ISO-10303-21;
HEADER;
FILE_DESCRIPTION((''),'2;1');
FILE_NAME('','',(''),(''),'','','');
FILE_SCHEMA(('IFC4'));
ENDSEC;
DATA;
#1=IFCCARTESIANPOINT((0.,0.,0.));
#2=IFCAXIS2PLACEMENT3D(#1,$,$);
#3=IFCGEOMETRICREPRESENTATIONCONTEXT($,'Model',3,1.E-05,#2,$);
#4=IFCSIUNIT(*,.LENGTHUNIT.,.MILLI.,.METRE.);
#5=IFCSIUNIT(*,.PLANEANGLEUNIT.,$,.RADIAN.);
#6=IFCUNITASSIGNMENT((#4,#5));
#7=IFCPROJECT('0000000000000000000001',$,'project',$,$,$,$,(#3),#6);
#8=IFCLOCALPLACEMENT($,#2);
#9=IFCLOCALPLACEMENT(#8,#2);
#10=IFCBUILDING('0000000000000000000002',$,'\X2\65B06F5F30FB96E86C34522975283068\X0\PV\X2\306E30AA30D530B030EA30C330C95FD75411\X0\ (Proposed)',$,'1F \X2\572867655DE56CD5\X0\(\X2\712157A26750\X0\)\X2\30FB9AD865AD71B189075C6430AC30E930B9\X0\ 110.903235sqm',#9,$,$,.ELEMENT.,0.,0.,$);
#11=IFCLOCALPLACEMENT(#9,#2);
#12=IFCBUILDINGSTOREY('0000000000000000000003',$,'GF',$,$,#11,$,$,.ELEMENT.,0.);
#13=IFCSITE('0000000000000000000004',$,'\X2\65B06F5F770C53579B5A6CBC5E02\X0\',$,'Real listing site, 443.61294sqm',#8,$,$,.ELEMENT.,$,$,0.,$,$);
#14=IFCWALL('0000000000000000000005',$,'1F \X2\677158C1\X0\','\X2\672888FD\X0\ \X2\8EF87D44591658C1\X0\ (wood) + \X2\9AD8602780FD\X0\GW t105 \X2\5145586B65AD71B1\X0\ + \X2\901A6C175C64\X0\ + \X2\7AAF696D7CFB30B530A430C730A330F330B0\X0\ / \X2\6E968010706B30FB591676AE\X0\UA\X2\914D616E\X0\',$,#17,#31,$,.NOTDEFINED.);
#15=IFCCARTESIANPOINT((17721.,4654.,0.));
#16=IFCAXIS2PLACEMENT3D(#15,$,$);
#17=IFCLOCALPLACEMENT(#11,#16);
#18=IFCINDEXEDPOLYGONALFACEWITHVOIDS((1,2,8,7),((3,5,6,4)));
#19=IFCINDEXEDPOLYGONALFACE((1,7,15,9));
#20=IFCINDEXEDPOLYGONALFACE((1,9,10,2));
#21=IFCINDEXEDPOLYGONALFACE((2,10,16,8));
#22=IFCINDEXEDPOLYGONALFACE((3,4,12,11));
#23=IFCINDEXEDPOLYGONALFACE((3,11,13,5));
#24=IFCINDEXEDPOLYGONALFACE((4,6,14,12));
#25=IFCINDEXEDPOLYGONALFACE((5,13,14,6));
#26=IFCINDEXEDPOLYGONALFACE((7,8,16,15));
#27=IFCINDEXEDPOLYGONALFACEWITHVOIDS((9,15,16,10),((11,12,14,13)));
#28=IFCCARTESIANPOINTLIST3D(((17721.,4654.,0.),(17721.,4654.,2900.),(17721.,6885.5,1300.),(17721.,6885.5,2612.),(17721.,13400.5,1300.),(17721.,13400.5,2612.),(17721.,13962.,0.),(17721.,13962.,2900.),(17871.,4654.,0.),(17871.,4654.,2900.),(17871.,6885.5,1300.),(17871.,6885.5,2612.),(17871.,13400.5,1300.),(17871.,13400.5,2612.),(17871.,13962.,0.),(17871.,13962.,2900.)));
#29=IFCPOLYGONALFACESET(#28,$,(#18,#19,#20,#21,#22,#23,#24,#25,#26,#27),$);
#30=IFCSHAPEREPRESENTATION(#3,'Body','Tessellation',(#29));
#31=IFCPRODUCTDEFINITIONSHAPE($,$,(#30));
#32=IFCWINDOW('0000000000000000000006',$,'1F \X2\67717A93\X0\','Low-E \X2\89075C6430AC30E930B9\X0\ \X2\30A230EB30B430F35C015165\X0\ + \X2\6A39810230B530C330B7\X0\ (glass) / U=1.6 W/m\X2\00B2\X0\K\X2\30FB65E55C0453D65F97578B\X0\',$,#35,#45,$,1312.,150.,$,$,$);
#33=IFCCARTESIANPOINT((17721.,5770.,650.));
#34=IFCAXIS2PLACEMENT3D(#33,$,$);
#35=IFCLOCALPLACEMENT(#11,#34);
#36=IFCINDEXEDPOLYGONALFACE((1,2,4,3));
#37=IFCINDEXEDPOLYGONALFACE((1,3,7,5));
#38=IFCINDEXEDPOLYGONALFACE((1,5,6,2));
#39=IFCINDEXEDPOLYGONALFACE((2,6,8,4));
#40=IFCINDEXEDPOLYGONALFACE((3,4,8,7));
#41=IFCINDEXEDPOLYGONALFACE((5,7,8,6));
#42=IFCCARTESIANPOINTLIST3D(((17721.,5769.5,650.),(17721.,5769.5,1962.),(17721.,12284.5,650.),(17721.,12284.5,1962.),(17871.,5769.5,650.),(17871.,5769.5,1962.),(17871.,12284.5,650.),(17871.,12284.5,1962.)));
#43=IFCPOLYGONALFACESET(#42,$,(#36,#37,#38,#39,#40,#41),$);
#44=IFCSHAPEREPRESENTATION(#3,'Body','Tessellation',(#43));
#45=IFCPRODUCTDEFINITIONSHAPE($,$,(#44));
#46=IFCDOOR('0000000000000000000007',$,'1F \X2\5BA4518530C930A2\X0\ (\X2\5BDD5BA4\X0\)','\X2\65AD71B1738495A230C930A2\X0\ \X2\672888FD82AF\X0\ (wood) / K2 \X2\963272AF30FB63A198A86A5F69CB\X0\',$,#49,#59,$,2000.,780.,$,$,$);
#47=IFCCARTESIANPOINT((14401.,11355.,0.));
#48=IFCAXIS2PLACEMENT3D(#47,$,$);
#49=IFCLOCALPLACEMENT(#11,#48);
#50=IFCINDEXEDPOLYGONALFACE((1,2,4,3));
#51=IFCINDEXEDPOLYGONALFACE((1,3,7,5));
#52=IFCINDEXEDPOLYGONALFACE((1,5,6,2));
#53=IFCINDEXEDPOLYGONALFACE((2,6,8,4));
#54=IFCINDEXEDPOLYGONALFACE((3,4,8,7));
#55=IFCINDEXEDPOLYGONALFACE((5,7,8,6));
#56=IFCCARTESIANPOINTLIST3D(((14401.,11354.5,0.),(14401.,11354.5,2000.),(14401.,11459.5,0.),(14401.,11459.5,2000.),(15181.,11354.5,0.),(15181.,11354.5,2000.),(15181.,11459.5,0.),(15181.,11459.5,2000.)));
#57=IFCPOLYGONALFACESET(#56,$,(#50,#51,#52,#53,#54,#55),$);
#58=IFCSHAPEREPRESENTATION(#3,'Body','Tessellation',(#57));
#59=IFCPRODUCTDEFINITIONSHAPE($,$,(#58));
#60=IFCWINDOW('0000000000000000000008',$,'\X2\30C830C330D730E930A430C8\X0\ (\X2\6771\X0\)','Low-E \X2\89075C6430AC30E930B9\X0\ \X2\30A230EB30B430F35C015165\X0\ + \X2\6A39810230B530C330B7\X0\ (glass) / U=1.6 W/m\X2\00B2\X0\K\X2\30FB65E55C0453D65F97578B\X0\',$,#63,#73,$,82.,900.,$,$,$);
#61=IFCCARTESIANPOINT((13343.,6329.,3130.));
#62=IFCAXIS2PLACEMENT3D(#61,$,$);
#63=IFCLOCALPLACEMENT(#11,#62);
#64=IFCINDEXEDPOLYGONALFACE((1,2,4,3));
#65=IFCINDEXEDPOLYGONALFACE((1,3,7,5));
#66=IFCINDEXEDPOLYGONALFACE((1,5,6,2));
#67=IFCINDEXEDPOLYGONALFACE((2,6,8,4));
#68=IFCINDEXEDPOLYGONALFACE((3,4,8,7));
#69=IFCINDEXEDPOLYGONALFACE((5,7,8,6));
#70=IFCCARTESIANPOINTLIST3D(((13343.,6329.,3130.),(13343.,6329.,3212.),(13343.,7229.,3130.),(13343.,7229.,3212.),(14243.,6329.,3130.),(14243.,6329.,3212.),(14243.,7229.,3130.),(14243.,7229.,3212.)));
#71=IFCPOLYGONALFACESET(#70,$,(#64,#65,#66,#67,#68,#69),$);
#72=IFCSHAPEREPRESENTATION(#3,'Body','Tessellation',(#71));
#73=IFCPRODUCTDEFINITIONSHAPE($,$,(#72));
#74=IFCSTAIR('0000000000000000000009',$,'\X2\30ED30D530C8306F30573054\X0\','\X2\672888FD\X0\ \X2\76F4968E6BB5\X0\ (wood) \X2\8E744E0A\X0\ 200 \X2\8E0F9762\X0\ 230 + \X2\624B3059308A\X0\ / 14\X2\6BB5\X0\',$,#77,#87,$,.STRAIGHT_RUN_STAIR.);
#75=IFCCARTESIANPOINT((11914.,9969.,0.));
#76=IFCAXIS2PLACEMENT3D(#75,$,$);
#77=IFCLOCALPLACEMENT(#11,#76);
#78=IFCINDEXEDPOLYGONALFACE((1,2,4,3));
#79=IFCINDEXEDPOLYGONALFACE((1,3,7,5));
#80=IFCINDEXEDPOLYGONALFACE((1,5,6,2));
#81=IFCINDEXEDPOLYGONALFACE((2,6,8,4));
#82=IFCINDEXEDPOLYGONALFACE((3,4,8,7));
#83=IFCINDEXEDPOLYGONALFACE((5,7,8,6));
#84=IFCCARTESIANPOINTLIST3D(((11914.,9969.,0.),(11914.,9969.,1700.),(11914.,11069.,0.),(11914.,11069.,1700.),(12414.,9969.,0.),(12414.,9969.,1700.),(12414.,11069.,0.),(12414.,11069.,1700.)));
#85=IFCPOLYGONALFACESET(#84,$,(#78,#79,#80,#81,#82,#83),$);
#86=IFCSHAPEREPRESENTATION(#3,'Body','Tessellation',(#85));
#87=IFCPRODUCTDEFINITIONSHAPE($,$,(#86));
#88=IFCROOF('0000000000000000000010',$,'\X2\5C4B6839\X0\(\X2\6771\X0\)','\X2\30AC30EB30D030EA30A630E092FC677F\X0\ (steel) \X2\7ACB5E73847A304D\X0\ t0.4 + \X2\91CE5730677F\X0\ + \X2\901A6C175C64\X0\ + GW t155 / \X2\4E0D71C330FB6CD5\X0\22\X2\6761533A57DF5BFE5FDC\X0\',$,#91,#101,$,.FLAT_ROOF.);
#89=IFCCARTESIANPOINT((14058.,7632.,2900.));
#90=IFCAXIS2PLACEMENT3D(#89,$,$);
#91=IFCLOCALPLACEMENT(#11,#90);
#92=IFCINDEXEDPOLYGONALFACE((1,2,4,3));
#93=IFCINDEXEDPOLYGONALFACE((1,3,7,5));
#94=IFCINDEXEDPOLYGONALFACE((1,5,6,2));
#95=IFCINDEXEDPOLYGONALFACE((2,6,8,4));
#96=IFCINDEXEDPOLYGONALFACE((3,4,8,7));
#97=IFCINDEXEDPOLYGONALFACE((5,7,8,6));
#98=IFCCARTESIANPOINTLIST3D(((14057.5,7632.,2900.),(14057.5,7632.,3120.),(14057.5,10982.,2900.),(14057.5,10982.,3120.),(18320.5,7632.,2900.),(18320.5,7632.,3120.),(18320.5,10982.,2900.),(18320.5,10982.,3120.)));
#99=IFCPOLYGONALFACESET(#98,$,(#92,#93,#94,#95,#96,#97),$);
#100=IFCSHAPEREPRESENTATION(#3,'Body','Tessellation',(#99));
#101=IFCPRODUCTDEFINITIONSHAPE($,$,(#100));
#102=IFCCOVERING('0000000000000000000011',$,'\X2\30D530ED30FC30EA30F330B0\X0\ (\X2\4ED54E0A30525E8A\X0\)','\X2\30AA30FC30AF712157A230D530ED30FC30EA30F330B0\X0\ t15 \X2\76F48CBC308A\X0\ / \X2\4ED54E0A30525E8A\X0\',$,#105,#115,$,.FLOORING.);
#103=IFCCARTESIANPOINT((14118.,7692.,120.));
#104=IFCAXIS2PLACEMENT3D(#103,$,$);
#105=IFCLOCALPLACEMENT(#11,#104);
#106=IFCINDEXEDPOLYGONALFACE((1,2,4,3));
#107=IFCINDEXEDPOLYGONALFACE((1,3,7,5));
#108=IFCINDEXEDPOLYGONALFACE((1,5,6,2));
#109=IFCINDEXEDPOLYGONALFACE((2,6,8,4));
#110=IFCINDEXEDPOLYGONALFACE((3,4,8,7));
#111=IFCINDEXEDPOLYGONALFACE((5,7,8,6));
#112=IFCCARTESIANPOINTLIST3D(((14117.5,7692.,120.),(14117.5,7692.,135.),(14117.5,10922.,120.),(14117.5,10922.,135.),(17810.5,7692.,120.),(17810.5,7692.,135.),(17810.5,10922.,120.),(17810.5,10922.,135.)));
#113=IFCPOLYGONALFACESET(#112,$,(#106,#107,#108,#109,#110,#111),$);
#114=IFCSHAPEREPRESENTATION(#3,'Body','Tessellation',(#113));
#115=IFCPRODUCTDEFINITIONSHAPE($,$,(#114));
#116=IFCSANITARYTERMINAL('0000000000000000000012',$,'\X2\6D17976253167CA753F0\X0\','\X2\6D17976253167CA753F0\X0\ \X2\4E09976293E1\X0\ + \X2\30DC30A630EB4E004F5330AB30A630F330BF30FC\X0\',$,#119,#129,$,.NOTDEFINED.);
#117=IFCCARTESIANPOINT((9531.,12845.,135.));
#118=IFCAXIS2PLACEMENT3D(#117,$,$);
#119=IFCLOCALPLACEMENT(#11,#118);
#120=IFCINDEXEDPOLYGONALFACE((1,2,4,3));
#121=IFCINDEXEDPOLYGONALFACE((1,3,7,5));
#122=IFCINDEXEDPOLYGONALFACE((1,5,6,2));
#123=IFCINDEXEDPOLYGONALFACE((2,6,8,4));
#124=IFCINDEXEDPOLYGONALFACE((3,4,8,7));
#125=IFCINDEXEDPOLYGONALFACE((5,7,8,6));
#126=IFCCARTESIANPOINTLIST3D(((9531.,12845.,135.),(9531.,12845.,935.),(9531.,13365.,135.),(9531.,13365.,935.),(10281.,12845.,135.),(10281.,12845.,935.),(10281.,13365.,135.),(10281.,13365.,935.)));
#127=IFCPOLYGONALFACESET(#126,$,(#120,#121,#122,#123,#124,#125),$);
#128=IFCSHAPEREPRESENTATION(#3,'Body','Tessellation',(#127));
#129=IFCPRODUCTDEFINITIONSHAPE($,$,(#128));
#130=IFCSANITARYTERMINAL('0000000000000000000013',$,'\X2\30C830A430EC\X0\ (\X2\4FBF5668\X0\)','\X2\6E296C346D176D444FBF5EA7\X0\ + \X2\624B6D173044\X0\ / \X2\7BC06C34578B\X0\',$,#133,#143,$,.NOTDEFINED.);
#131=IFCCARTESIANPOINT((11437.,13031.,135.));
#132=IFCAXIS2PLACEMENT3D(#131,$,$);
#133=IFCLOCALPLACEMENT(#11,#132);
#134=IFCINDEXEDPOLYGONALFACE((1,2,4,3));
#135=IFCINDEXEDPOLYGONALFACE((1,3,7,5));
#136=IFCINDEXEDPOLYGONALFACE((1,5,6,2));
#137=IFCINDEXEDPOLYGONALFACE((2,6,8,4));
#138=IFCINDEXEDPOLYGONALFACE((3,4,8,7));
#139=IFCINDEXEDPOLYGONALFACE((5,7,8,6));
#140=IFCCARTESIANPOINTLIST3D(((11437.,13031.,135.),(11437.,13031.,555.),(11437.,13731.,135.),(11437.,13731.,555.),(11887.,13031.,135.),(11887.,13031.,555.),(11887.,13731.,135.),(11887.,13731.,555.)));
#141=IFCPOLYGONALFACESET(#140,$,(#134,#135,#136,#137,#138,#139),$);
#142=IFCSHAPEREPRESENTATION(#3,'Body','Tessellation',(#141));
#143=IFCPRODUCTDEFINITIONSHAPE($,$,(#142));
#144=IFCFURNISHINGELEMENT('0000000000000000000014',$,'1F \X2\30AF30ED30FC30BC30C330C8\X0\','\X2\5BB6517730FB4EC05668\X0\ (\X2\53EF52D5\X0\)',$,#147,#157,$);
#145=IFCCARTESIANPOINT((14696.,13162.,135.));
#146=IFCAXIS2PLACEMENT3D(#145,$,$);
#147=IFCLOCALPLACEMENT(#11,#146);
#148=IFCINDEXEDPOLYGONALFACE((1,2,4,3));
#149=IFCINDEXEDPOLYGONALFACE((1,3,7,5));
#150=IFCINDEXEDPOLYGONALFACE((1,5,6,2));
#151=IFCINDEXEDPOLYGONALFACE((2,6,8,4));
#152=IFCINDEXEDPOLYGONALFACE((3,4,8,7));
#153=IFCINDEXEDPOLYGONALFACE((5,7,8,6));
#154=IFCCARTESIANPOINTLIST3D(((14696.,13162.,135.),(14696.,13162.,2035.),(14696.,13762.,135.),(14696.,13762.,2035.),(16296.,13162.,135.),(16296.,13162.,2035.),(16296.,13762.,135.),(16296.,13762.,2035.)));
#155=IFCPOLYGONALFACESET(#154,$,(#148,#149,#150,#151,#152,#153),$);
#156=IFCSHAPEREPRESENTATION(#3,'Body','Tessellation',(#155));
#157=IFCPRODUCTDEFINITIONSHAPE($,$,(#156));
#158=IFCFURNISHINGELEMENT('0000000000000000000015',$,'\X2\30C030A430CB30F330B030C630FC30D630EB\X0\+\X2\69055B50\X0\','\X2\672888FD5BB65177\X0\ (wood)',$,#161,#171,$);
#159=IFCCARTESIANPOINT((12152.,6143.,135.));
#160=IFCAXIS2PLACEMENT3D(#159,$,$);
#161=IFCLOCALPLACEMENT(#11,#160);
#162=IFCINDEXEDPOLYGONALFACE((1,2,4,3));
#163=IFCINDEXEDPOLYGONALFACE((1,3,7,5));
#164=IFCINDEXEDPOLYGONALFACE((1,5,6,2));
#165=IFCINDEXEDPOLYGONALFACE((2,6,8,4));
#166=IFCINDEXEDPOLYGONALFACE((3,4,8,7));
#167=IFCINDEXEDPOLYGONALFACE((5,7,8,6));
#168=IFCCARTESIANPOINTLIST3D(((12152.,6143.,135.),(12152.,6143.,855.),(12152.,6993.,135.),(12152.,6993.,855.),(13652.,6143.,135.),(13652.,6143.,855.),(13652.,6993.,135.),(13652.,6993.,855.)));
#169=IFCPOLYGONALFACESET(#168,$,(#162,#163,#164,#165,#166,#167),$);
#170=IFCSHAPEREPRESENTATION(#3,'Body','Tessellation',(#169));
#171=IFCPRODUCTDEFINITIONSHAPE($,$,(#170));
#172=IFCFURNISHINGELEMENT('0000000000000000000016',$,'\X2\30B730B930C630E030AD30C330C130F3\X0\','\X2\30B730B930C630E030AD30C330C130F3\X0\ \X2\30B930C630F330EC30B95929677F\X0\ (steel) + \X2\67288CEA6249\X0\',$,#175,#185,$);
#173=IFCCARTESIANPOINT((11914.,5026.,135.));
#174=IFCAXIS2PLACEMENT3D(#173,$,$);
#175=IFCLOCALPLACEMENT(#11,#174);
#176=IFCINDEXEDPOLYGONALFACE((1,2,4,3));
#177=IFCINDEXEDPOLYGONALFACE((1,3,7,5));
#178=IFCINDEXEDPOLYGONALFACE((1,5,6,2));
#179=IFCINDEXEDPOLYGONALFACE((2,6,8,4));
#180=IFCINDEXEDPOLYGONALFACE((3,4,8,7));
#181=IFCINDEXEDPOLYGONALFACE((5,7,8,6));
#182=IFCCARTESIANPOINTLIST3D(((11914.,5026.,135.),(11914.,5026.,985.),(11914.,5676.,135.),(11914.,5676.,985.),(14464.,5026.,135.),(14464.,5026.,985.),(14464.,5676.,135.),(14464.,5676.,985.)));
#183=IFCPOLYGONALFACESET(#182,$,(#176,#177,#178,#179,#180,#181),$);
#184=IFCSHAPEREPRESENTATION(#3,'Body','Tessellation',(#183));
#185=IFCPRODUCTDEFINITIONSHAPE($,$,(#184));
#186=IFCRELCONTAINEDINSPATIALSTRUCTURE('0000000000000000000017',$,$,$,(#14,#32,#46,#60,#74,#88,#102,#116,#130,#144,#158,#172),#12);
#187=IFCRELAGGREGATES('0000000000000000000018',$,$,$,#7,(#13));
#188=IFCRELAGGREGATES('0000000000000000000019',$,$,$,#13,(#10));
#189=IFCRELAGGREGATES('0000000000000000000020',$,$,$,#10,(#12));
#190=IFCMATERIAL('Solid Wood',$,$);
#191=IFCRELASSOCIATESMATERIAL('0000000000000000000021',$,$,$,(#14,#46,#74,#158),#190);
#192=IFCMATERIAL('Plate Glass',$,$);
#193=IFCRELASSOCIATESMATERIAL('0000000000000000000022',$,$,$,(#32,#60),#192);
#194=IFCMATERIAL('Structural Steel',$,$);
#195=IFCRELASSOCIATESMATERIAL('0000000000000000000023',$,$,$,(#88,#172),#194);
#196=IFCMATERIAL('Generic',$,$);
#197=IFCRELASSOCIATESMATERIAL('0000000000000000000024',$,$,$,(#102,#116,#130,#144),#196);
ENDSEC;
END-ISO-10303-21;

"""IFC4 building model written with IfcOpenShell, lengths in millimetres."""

from ifc_helpers import new_model, si_unit, frame, frame_2d, origin, place, context, project, spatial, rectangle, extrude, material, element, fill, save


model = new_model("IFC4")

# Units and contexts
model_context = context("Model", 3, precision=1e-05, world=origin())
ifc_project = project(units=[si_unit("LENGTHUNIT", "METRE", prefix="MILLI"), si_unit("PLANEANGLEUNIT", "RADIAN")], contexts=[model_context])

# Site, building, storey
site_placement = place(None, origin())
site = spatial("IfcSite", under=ifc_project, at=site_placement, Name="新潟県南魚沼市", ObjectType="Real listing site, 443.61294sqm", CompositionType="ELEMENT", RefElevation=0.0)
building_placement = place(site_placement, origin())
building = spatial("IfcBuilding", under=site, at=building_placement, Name="新潟・雨水利用とPVのオフグリッド志向 (Proposed)", ObjectType="1F 在来工法(無垢材)・高断熱複層ガラス 110.903235sqm", CompositionType="ELEMENT", ElevationOfRefHeight=0.0, ElevationOfTerrain=0.0)
storey_placement = place(building_placement, origin())
storey = spatial("IfcBuildingStorey", under=building, at=storey_placement, Name="GF", CompositionType="ELEMENT", Elevation=0.0)

# Shared definitions
ifc_material_1 = material(Name="Solid Wood")

# Wall, opening, window
wall_1_placement = place(storey_placement, frame((17721.0, 4654.0, 0.0)))
wall_1 = element("IfcWall", 1, at=wall_1_placement, inside=storey, material=ifc_material_1, Name="1F 東壁", Description="木製 軸組外壁 (wood) + 高性能GW t105 充填断熱 + 通気層 + 窯業系サイディング / 準耐火・外皮UA配慮", PredefinedType="NOTDEFINED", context=model_context, shape_type="SweptSolid", body=[
    extrude(rectangle(XDim=150.0, YDim=9308.0, at=frame_2d((75.0, 4654.0))), frame((17721.0, 4654.0, 0.0)), (0.0, 0.0, 1.0), 2900.0),
])
opening_1_placement = place(storey_placement, frame((17721.0, 5770.0, 650.0)))
opening_1 = element("IfcOpeningElement", 2, at=opening_1_placement, cuts=wall_1, PredefinedType="NOTDEFINED", context=model_context, shape_type="SweptSolid", body=[
    extrude(rectangle(XDim=150.0, YDim=6515.0, at=frame_2d((75.0, 3257.0))), frame((17721.0, 5770.0, 650.0)), (0.0, 0.0, 1.0), 1312.0),
])
ifc_material_2 = material(Name="Plate Glass")
window_1_placement = place(storey_placement, frame((17721.0, 5770.0, 650.0)))
window_1 = element("IfcWindow", 3, at=window_1_placement, inside=storey, material=ifc_material_2, Name="1F 東窓", Description="Low-E 複層ガラス アルゴン封入 + 樹脂サッシ (glass) / U=1.6 W/m²K・日射取得型", OverallHeight=1312.0, OverallWidth=150.0, context=model_context, shape_type="SweptSolid", body=[
    extrude(rectangle(XDim=150.0, YDim=6515.0, at=frame_2d((75.0, 3257.0))), frame((17721.0, 5770.0, 650.0)), (0.0, 0.0, 1.0), 1312.0),
])
fill(opening_1, window_1)

# Door
door_placement = place(storey_placement, frame((14401.0, 11355.0, 0.0)))
element("IfcDoor", 4, at=door_placement, inside=storey, material=ifc_material_1, Name="1F 室内ドア (寝室)", Description="断熱玄関ドア 木製芯 (wood) / K2 防犯・採風機構", OverallHeight=2000.0, OverallWidth=780.0, context=model_context, shape_type="SweptSolid", body=[
    extrude(rectangle(XDim=780.0, YDim=105.0, at=frame_2d((390.0, 52.0))), frame((14401.0, 11355.0, 0.0)), (0.0, 0.0, 1.0), 2000.0),
])

# Window
window_2_placement = place(storey_placement, frame((13343.0, 6329.0, 3130.0)))
element("IfcWindow", 5, at=window_2_placement, inside=storey, material=ifc_material_2, Name="トップライト (東)", Description="Low-E 複層ガラス アルゴン封入 + 樹脂サッシ (glass) / U=1.6 W/m²K・日射取得型", OverallHeight=82.0, OverallWidth=900.0, context=model_context, shape_type="SweptSolid", body=[
    extrude(rectangle(XDim=900.0, YDim=900.0, at=frame_2d((450.0, 450.0))), frame((13343.0, 6329.0, 3130.0)), (0.0, 0.0, 1.0), 82.0),
])

# Stair
stair_placement = place(storey_placement, frame((11914.0, 9969.0, 0.0)))
element("IfcStair", 6, at=stair_placement, inside=storey, material=ifc_material_1, Name="ロフトはしご", Description="木製 直階段 (wood) 蹴上 200 踏面 230 + 手すり / 14段", PredefinedType="STRAIGHT_RUN_STAIR", context=model_context, shape_type="SweptSolid", body=[
    extrude(rectangle(XDim=500.0, YDim=1100.0, at=frame_2d((250.0, 550.0))), frame((11914.0, 9969.0, 0.0)), (0.0, 0.0, 1.0), 1700.0),
])

# Roof
ifc_material_3 = material(Name="Structural Steel")
roof_placement = place(storey_placement, frame((14058.0, 7632.0, 2900.0)))
element("IfcRoof", 7, at=roof_placement, inside=storey, material=ifc_material_3, Name="屋根(東)", Description="ガルバリウム鋼板 (steel) 立平葺き t0.4 + 野地板 + 通気層 + GW t155 / 不燃・法22条区域対応", PredefinedType="FLAT_ROOF", context=model_context, shape_type="SweptSolid", body=[
    extrude(rectangle(XDim=4263.0, YDim=3350.0, at=frame_2d((2131.0, 1675.0))), frame((14058.0, 7632.0, 2900.0)), (0.0, 0.0, 1.0), 220.0),
])

# Covering
ifc_material_4 = material(Name="Generic")
covering_placement = place(storey_placement, frame((14118.0, 7692.0, 120.0)))
element("IfcCovering", 8, at=covering_placement, inside=storey, material=ifc_material_4, Name="フローリング (仕上げ床)", Description="オーク無垢フローリング t15 直貼り / 仕上げ床", PredefinedType="FLOORING", context=model_context, shape_type="SweptSolid", body=[
    extrude(rectangle(XDim=3693.0, YDim=3230.0, at=frame_2d((1846.0, 1615.0))), frame((14118.0, 7692.0, 120.0)), (0.0, 0.0, 1.0), 15.0),
])

# Sanitary terminals
sanitary_terminal_1_placement = place(storey_placement, frame((9531.0, 12845.0, 135.0)))
element("IfcSanitaryTerminal", 9, at=sanitary_terminal_1_placement, inside=storey, material=ifc_material_4, Name="洗面化粧台", Description="洗面化粧台 三面鏡 + ボウル一体カウンター", PredefinedType="NOTDEFINED", context=model_context, shape_type="SweptSolid", body=[
    extrude(rectangle(XDim=750.0, YDim=520.0, at=frame_2d((375.0, 260.0))), frame((9531.0, 12845.0, 135.0)), (0.0, 0.0, 1.0), 800.0),
])
sanitary_terminal_2_placement = place(storey_placement, frame((11437.0, 13031.0, 135.0)))
element("IfcSanitaryTerminal", 10, at=sanitary_terminal_2_placement, inside=storey, material=ifc_material_4, Name="トイレ (便器)", Description="温水洗浄便座 + 手洗い / 節水型", PredefinedType="NOTDEFINED", context=model_context, shape_type="SweptSolid", body=[
    extrude(rectangle(XDim=450.0, YDim=700.0, at=frame_2d((225.0, 350.0))), frame((11437.0, 13031.0, 135.0)), (0.0, 0.0, 1.0), 420.0),
])

# Furnishing elements
furnishing_1_placement = place(storey_placement, frame((14696.0, 13162.0, 135.0)))
element("IfcFurnishingElement", 11, at=furnishing_1_placement, inside=storey, material=ifc_material_4, Name="1F クローゼット", Description="家具・什器 (可動)", context=model_context, shape_type="SweptSolid", body=[
    extrude(rectangle(XDim=1600.0, YDim=600.0, at=frame_2d((800.0, 300.0))), frame((14696.0, 13162.0, 135.0)), (0.0, 0.0, 1.0), 1900.0),
])
furnishing_2_placement = place(storey_placement, frame((12152.0, 6143.0, 135.0)))
element("IfcFurnishingElement", 12, at=furnishing_2_placement, inside=storey, material=ifc_material_1, Name="ダイニングテーブル+椅子", Description="木製家具 (wood)", context=model_context, shape_type="SweptSolid", body=[
    extrude(rectangle(XDim=1500.0, YDim=850.0, at=frame_2d((750.0, 425.0))), frame((12152.0, 6143.0, 135.0)), (0.0, 0.0, 1.0), 720.0),
])
furnishing_3_placement = place(storey_placement, frame((11914.0, 5026.0, 135.0)))
element("IfcFurnishingElement", 13, at=furnishing_3_placement, inside=storey, material=ifc_material_3, Name="システムキッチン", Description="システムキッチン ステンレス天板 (steel) + 木質扉", context=model_context, shape_type="SweptSolid", body=[
    extrude(rectangle(XDim=2550.0, YDim=650.0, at=frame_2d((1275.0, 325.0))), frame((11914.0, 5026.0, 135.0)), (0.0, 0.0, 1.0), 850.0),
])

save(model, "model.ifc")
